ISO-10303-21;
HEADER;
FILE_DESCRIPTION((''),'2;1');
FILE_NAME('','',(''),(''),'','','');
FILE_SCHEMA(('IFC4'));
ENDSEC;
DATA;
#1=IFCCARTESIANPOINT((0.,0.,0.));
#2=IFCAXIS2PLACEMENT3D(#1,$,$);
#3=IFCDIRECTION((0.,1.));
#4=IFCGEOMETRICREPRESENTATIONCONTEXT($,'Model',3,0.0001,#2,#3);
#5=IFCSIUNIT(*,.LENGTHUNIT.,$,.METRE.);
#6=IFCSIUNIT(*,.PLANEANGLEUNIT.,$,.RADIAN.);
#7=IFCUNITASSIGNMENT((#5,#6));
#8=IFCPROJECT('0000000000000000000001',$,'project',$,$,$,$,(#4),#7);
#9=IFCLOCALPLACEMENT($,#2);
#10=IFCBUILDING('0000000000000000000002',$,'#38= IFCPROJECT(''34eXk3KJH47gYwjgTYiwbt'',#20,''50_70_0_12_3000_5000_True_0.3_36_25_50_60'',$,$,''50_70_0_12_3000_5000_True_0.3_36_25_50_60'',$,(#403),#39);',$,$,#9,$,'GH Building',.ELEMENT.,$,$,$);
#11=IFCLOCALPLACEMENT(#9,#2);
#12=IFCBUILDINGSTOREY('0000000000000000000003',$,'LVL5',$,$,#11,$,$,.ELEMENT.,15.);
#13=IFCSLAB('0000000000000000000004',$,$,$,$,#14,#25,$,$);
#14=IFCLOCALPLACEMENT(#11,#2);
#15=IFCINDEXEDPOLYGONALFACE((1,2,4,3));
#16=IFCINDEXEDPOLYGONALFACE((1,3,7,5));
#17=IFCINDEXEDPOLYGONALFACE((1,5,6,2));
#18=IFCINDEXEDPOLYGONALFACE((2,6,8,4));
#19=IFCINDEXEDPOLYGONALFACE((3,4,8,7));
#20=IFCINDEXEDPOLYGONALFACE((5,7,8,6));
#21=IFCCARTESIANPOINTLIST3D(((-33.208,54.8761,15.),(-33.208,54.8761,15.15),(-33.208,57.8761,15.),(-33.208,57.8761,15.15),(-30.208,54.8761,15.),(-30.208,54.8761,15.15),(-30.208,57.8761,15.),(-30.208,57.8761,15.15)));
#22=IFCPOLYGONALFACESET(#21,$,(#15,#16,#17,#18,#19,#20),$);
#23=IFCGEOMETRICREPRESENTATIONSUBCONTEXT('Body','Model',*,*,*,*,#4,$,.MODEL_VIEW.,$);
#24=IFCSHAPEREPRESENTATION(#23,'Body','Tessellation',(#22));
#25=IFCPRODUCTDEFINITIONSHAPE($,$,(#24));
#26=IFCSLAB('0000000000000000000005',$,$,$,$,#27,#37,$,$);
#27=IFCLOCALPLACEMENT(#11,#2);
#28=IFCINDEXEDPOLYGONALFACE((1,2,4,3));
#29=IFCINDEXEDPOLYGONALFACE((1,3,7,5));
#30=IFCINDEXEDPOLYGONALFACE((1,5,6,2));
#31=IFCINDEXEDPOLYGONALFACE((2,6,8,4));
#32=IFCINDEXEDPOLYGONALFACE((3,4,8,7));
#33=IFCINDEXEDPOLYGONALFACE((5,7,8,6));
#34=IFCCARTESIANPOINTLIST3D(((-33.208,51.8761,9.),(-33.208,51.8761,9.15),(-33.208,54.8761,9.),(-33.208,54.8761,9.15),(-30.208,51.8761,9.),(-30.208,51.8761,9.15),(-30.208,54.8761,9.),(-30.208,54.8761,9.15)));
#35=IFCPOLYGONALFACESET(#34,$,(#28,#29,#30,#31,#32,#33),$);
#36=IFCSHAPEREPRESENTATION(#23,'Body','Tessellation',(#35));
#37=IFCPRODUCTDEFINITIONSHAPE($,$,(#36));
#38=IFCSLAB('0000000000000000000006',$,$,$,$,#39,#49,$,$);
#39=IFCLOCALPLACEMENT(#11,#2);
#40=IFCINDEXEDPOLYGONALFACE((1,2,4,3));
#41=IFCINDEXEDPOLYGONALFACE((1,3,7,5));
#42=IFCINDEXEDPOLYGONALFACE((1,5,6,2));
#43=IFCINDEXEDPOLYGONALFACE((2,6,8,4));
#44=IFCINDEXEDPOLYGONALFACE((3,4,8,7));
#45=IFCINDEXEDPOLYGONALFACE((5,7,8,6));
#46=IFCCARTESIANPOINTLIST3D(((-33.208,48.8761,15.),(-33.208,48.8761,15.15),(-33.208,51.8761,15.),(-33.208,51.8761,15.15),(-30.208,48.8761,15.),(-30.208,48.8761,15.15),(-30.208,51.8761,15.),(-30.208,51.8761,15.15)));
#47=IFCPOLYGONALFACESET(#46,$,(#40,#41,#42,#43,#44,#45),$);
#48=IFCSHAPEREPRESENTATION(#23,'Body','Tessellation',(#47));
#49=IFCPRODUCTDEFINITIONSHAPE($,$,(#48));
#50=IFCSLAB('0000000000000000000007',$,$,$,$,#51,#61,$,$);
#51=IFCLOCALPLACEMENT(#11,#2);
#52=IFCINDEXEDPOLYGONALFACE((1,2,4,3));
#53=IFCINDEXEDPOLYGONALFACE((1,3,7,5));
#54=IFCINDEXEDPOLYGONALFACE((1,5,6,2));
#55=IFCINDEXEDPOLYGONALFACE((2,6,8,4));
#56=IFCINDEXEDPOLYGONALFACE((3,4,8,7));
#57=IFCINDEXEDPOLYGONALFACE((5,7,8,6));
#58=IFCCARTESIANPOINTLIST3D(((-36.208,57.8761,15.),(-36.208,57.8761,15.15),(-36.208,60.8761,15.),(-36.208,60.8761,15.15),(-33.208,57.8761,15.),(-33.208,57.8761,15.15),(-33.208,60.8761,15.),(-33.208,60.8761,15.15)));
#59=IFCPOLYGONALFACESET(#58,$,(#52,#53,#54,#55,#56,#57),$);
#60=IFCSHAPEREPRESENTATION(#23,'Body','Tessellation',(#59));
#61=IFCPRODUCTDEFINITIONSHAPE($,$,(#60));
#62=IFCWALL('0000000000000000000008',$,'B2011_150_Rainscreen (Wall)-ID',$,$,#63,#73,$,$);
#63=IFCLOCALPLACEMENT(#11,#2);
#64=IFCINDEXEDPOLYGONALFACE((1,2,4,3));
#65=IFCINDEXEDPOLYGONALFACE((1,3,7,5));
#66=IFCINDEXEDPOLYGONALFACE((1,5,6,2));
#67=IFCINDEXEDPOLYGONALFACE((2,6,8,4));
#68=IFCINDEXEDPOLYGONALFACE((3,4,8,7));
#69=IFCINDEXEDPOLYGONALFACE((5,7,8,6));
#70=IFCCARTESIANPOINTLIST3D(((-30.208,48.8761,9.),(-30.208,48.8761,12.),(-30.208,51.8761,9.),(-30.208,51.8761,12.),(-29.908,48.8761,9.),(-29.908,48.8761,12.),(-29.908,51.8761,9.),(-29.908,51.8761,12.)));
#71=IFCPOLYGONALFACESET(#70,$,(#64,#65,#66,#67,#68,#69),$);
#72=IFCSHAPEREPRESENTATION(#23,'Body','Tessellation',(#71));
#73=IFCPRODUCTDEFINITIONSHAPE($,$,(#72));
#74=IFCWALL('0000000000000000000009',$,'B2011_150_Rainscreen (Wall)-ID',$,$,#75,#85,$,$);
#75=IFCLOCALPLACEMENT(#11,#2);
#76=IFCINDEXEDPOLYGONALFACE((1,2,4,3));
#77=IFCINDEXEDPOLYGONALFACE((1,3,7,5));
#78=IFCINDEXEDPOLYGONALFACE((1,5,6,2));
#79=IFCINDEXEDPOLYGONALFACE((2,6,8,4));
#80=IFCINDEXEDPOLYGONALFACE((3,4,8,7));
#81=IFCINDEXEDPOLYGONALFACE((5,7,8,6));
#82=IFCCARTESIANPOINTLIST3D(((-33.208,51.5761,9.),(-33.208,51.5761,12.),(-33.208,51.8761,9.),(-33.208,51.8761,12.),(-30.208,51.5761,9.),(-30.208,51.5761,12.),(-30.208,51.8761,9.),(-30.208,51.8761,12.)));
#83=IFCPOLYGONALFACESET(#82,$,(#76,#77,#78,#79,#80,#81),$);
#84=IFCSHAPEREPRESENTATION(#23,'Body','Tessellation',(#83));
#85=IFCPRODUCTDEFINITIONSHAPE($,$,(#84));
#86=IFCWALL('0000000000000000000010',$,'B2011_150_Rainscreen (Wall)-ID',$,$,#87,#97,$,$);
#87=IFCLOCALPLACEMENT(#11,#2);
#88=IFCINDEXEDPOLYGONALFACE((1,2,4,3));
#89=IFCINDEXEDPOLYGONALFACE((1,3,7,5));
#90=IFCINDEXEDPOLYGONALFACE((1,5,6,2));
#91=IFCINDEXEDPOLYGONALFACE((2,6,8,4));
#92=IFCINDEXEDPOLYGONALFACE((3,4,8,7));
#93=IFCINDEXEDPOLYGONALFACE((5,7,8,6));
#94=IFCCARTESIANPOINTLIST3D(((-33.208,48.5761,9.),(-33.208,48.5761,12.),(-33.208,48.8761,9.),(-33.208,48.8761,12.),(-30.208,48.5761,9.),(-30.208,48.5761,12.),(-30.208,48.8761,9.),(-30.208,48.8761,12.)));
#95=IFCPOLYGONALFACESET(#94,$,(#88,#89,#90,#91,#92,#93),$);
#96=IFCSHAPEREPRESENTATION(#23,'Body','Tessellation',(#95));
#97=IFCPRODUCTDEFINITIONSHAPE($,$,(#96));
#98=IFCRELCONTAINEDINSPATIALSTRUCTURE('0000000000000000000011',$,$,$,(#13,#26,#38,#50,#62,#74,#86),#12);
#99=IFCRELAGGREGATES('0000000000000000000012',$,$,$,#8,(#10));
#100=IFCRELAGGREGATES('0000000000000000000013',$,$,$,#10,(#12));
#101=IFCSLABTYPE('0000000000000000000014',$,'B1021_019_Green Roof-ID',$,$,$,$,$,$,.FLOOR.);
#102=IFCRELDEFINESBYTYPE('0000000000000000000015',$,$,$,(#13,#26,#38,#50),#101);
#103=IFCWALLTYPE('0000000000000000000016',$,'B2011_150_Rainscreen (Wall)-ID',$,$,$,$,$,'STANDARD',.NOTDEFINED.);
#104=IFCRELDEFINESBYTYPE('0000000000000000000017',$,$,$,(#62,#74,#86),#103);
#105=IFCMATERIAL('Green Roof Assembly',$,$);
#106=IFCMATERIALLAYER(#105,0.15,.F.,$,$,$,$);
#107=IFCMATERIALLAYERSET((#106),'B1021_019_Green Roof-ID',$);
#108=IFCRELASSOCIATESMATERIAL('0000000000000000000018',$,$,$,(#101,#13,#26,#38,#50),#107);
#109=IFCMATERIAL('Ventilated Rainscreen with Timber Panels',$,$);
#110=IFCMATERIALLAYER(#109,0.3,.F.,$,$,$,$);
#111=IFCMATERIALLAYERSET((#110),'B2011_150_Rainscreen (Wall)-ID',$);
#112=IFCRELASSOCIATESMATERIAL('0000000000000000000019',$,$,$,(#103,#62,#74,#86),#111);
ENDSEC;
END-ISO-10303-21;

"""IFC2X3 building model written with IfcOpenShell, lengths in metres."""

from ifc_helpers import new_model, si_unit, direction, frame, frame_2d, origin, place, context, subcontext, project, spatial, polyline, rectangle, outline, extrude, material, layer, layer_set, layer_usage, type_object, element, save


model = new_model("IFC2X3")

# Units and contexts
model_context = context("Model", 3, precision=0.0001, world=origin(), true_north=direction((0.0, 1.0)))
body_context = subcontext(model_context, "Body", "Model", "MODEL_VIEW")
ifc_project = project(units=[si_unit("LENGTHUNIT", "METRE"), si_unit("PLANEANGLEUNIT", "RADIAN")], contexts=[model_context])

# Building, storey
building_placement = place(None, origin())
building = spatial("IfcBuilding", under=ifc_project, at=building_placement, Name="#38= IFCPROJECT('34eXk3KJH47gYwjgTYiwbt',#20,'50_70_0_12_3000_5000_True_0.3_36_25_50_60',$,$,'50_70_0_12_3000_5000_True_0.3_36_25_50_60',$,(#403),#39);", LongName="GH Building", CompositionType="ELEMENT")
storey_placement = place(building_placement, origin())
storey = spatial("IfcBuildingStorey", under=building, at=storey_placement, Name="LVL5", CompositionType="ELEMENT", Elevation=15.0)

# Slabs
ifc_material_1 = material(Name="Green Roof Assembly")
ifc_layer_1 = layer(ifc_material_1, 0.15, ventilated=False)
ifc_layer_set_1 = layer_set([ifc_layer_1], Name="B1021_019_Green Roof-ID")
slab_type_1 = type_object("IfcSlabType", Name="B1021_019_Green Roof-ID", PredefinedType="FLOOR", material=ifc_layer_set_1)
ifc_layer_usage_1 = layer_usage(ifc_layer_set_1, "AXIS3", "NEGATIVE", -0.15)
slab_1_placement = place(storey_placement, frame((-31.708, 56.3761, 15.0)))
element("IfcSlab", 1, at=slab_1_placement, inside=storey, type_object=slab_type_1, material=ifc_layer_usage_1, context=body_context, shape_type="SweptSolid", body=[
    extrude(outline(polyline([(1.5, -1.5), (-1.5, -1.5), (-1.5, 1.5), (1.5, 1.5), (1.5, -1.5)])), origin(), (0.0, 0.0, 1.0), 0.15),
])
ifc_layer_usage_2 = layer_usage(ifc_layer_set_1, "AXIS3", "NEGATIVE", -0.15)
slab_2_placement = place(storey_placement, frame((-31.708, 53.3761, 9.0)))
element("IfcSlab", 2, at=slab_2_placement, inside=storey, type_object=slab_type_1, material=ifc_layer_usage_2, context=body_context, shape_type="SweptSolid", body=[
    extrude(outline(polyline([(-1.5, 1.5), (1.5, 1.5), (1.5, -1.5), (-1.5, -1.5), (-1.5, 1.5)])), origin(), (0.0, 0.0, 1.0), 0.15),
])
ifc_layer_usage_3 = layer_usage(ifc_layer_set_1, "AXIS3", "NEGATIVE", -0.15)
slab_3_placement = place(storey_placement, frame((-31.708, 50.3761, 15.0)))
element("IfcSlab", 3, at=slab_3_placement, inside=storey, type_object=slab_type_1, material=ifc_layer_usage_3, context=body_context, shape_type="SweptSolid", body=[
    extrude(outline(polyline([(-1.5, 1.5), (1.5, 1.5), (1.5, -1.5), (-1.5, -1.5), (-1.5, 1.5)])), origin(), (0.0, 0.0, 1.0), 0.15),
])
ifc_layer_usage_4 = layer_usage(ifc_layer_set_1, "AXIS3", "NEGATIVE", -0.15)
slab_4_placement = place(storey_placement, frame((-34.708, 59.3761, 15.0)))
element("IfcSlab", 4, at=slab_4_placement, inside=storey, type_object=slab_type_1, material=ifc_layer_usage_4, context=body_context, shape_type="SweptSolid", body=[
    extrude(outline(polyline([(-1.5, 1.5), (1.5, 1.5), (1.5, -1.5), (-1.5, -1.5), (-1.5, 1.5)])), origin(), (0.0, 0.0, 1.0), 0.15),
])

# Walls
ifc_material_2 = material(Name="Ventilated Rainscreen with Timber Panels")
ifc_layer_2 = layer(ifc_material_2, 0.3, ventilated=False)
ifc_layer_set_2 = layer_set([ifc_layer_2], Name="B2011_150_Rainscreen (Wall)-ID")
ifc_layer_usage_5 = layer_usage(ifc_layer_set_2, "AXIS2", "POSITIVE", 0.0)
wall_type = type_object("IfcWallType", Name="B2011_150_Rainscreen (Wall)-ID", ElementType="STANDARD", PredefinedType="NOTDEFINED", material=ifc_layer_set_2)
wall_1_placement = place(storey_placement, frame((-30.208, 51.8761, 9.0), z_axis=(0.0, 0.0, 1.0), x_axis=(0.0, -1.0, 0.0)))
element("IfcWall", 5, at=wall_1_placement, inside=storey, type_object=wall_type, material=ifc_layer_usage_5, Name="B2011_150_Rainscreen (Wall)-ID", context=body_context, shape_type="SweptSolid", body=[
    extrude(rectangle(XDim=3.0, YDim=0.3, at=frame_2d((1.5, 0.15))), origin(), (0.0, 0.0, 1.0), 3.0),
])
ifc_layer_usage_6 = layer_usage(ifc_layer_set_2, "AXIS2", "POSITIVE", 0.0)
wall_2_placement = place(storey_placement, frame((-30.208, 51.8761, 9.0), z_axis=(0.0, 0.0, 1.0), x_axis=(-1.0, 0.0, 0.0)))
element("IfcWall", 6, at=wall_2_placement, inside=storey, type_object=wall_type, material=ifc_layer_usage_6, Name="B2011_150_Rainscreen (Wall)-ID", context=body_context, shape_type="SweptSolid", body=[
    extrude(rectangle(XDim=3.0, YDim=0.3, at=frame_2d((1.5, 0.15))), origin(), (0.0, 0.0, 1.0), 3.0),
])
ifc_layer_usage_7 = layer_usage(ifc_layer_set_2, "AXIS2", "POSITIVE", 0.0)
wall_3_placement = place(storey_placement, frame((-30.208, 48.8761, 9.0), z_axis=(0.0, 0.0, 1.0), x_axis=(-1.0, 0.0, 0.0)))
element("IfcWall", 7, at=wall_3_placement, inside=storey, type_object=wall_type, material=ifc_layer_usage_7, Name="B2011_150_Rainscreen (Wall)-ID", context=body_context, shape_type="SweptSolid", body=[
    extrude(rectangle(XDim=3.0, YDim=0.3, at=frame_2d((1.5, 0.15))), origin(), (0.0, 0.0, 1.0), 3.0),
])

save(model, "model.ifc")
